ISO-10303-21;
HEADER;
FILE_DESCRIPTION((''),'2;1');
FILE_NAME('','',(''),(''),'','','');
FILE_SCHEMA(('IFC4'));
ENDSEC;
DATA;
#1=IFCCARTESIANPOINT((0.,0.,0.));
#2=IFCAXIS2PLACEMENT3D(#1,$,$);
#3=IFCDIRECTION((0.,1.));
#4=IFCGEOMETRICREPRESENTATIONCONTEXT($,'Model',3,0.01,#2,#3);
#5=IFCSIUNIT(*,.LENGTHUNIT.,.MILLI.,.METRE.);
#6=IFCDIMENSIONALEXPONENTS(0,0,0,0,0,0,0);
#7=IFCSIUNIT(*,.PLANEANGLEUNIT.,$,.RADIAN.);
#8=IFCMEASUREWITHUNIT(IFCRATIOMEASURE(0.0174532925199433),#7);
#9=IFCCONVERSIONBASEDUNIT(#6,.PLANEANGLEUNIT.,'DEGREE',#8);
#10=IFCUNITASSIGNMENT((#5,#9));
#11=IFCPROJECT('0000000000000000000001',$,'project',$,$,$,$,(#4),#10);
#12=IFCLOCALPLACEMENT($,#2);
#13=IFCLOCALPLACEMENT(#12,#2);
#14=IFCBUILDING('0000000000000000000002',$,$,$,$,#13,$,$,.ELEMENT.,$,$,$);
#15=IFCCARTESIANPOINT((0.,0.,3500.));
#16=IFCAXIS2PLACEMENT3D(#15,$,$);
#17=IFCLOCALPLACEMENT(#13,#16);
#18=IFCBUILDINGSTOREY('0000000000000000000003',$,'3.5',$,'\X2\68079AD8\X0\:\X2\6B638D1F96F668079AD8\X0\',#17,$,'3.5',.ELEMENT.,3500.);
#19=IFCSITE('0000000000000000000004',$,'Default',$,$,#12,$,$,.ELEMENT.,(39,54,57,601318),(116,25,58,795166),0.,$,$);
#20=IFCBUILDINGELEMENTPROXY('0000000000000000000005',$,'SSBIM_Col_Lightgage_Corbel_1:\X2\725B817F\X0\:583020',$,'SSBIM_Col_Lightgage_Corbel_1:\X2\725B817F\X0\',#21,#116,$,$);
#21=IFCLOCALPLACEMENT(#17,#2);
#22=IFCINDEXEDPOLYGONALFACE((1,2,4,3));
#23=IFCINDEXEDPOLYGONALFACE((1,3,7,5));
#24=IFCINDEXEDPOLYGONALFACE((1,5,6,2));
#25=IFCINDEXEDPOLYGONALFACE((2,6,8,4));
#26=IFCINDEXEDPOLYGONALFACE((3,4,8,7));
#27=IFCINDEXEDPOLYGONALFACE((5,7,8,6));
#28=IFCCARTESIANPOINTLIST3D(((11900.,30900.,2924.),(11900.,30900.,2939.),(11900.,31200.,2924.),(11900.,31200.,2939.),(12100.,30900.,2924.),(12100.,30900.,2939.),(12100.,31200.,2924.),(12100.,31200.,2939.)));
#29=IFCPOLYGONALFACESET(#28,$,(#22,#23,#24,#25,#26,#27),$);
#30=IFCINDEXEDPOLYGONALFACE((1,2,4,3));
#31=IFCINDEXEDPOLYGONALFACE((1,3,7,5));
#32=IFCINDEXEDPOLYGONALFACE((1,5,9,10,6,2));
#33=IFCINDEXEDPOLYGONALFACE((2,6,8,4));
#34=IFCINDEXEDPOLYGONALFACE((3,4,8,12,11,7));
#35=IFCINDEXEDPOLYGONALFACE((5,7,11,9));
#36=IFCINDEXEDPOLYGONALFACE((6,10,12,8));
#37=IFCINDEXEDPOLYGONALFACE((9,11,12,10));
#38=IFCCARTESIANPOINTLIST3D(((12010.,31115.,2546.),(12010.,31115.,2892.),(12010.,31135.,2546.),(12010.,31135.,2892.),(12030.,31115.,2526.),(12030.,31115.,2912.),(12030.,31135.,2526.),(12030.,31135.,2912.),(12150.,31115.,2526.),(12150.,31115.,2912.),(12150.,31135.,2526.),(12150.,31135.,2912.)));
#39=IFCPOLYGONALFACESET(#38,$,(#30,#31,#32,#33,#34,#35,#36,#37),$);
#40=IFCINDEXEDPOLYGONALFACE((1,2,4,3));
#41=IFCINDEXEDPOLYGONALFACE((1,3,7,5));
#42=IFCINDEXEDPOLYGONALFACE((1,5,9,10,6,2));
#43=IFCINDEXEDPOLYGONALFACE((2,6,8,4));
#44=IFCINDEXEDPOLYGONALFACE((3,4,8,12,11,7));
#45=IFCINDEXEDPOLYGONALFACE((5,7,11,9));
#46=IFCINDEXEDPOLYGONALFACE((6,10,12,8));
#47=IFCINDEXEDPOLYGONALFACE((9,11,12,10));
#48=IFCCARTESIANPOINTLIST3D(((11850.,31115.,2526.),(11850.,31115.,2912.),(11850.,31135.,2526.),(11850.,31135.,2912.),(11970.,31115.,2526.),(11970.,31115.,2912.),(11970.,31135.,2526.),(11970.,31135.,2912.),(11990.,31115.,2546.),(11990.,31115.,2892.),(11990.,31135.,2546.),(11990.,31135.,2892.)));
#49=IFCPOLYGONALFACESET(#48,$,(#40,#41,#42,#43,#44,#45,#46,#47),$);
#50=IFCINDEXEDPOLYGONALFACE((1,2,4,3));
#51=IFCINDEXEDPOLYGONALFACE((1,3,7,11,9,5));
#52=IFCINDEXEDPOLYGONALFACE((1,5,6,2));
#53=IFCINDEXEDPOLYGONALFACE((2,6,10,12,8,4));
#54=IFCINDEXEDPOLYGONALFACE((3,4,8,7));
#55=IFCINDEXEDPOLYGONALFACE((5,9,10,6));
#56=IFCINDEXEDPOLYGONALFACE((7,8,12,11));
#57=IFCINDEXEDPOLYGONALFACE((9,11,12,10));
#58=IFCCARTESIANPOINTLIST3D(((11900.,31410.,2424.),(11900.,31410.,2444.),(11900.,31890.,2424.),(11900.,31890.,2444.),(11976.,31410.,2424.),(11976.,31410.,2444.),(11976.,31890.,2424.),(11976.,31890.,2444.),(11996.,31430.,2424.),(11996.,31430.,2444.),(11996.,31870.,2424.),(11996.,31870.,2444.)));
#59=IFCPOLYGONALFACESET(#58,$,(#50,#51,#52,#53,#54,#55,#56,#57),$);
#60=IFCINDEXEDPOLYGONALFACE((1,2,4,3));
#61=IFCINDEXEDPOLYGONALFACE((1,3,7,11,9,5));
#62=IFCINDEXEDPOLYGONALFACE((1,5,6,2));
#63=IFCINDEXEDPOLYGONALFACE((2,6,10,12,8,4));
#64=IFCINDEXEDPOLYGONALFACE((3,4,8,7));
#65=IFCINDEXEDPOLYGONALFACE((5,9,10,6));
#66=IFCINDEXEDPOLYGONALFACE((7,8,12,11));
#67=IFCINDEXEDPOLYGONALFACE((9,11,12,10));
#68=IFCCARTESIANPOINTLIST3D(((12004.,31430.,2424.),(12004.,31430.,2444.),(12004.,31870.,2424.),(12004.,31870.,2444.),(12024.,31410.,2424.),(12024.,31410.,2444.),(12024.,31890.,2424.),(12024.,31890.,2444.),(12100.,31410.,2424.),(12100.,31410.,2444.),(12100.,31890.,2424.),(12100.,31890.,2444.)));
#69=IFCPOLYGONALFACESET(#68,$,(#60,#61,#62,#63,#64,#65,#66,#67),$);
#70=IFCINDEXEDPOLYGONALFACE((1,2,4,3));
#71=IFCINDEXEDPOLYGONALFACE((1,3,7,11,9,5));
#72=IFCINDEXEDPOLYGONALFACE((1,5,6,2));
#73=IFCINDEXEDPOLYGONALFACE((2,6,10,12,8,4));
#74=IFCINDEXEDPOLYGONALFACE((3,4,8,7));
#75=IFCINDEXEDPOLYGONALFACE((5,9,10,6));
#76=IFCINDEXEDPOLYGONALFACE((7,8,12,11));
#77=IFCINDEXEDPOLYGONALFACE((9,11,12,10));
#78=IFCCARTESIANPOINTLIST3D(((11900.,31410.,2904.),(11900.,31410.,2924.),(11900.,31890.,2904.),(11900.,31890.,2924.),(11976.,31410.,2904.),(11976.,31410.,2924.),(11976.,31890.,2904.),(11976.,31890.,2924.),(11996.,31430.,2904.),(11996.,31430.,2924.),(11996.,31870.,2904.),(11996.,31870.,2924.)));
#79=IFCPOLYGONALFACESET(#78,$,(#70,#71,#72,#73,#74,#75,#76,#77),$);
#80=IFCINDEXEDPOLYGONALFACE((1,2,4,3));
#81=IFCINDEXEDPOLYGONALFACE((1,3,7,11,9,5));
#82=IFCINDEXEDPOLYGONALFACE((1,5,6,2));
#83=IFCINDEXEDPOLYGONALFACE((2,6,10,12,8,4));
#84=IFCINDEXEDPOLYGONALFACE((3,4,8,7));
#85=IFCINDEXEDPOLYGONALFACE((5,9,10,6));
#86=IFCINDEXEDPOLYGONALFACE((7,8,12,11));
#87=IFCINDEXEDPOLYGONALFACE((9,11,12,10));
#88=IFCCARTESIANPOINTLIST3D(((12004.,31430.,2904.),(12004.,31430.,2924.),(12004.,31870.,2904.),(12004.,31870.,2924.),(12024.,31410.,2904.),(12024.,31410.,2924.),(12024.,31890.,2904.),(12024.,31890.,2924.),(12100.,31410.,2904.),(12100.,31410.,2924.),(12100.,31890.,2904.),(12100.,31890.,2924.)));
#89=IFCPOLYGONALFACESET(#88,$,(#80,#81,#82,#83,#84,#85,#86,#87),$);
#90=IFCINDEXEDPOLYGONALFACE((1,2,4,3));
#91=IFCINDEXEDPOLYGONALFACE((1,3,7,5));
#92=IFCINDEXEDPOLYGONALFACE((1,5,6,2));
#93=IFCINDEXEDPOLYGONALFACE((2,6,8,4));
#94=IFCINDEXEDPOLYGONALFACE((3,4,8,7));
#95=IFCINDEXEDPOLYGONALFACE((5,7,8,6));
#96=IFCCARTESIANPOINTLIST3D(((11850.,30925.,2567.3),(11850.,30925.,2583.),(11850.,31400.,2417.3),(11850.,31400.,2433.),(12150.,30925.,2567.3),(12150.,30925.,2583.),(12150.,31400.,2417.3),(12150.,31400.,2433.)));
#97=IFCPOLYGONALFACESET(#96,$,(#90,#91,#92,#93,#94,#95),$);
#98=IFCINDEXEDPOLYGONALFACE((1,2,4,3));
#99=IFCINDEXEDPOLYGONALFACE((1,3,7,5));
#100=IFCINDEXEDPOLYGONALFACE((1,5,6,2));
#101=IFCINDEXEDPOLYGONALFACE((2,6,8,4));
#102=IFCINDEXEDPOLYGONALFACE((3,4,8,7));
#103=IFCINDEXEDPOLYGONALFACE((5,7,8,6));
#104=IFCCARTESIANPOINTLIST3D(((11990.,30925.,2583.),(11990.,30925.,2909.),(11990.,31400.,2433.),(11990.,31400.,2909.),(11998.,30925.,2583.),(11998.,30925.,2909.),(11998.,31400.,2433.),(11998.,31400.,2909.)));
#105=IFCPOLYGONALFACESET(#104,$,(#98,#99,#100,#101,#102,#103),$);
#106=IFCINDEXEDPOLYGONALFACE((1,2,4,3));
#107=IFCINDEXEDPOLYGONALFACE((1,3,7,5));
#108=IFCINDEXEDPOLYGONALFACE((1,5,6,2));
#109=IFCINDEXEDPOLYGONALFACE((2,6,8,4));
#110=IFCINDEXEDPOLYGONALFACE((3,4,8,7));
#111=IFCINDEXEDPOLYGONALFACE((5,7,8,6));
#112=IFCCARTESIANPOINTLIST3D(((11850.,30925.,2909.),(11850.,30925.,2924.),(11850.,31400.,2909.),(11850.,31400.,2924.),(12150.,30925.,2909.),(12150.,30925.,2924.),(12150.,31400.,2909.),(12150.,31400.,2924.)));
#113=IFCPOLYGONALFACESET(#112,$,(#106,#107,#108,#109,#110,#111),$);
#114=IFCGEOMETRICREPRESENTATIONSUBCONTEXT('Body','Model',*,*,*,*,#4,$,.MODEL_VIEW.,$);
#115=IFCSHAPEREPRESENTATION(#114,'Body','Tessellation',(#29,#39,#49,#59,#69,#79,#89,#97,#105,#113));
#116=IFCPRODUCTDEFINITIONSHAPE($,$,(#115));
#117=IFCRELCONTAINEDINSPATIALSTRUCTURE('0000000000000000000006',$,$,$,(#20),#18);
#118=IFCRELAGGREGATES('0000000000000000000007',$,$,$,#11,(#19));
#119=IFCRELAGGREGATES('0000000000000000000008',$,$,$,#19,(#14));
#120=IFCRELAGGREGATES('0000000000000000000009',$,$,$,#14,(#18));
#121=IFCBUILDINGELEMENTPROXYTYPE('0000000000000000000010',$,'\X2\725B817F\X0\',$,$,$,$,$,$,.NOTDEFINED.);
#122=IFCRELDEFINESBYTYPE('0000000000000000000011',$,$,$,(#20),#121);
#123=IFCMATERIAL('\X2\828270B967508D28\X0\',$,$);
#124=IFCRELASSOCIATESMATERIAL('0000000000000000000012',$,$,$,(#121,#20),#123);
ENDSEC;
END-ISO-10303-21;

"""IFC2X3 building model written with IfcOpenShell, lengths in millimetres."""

from ifc_helpers import new_model, entity, si_unit, converted_unit, direction, frame, frame_2d, origin, origin_2d_with_axis, place, context, subcontext, project, spatial, polyline, rectangle, outline, extrude, source, transform, mapped, material, type_object, type_shapes, element, save


model = new_model("IFC2X3")

# Units and contexts
model_context = context("Model", 3, precision=0.01, world=origin(), true_north=direction((0.0, 1.0)))
body_context = subcontext(model_context, "Body", "Model", "MODEL_VIEW")
ifc_project = project(units=[si_unit("LENGTHUNIT", "METRE", prefix="MILLI"), converted_unit("PLANEANGLEUNIT", "DEGREE", entity("IfcRatioMeasure", 0.0174532925199433), si_unit("PLANEANGLEUNIT", "RADIAN"), dimensions=[0, 0, 0, 0, 0, 0, 0])], contexts=[model_context])

# Site, building, storey
site_placement = place(None, origin())
site = spatial("IfcSite", under=ifc_project, at=site_placement, Name="Default", CompositionType="ELEMENT", RefLatitude=(39, 54, 57, 601318), RefLongitude=(116, 25, 58, 795166), RefElevation=0.0)
building_placement = place(site_placement, origin())
building = spatial("IfcBuilding", under=site, at=building_placement, CompositionType="ELEMENT")
storey_placement = place(building_placement, frame((0.0, 0.0, 3500.0)))
storey = spatial("IfcBuildingStorey", under=building, at=storey_placement, Name="3.5", ObjectType="标高:正负零标高", LongName="3.5", CompositionType="ELEMENT", Elevation=3500.0)

# Building element proxy
ifc_material_1 = material(Name="节点材质")
building_element_proxy_type_1 = type_object("IfcBuildingElementProxyType", Name="牛腿", PredefinedType="NOTDEFINED", material=ifc_material_1)
shared_shape_1 = source(origin(), body_context, "Body", "SweptSolid", [
    extrude(rectangle(XDim=300.0, YDim=200.0, at=frame_2d((0.0, 0.0), x_axis=(1.0, 0.0))), frame((636.4, 0.0, 0.0)), (0.0, 0.0, 1.0), 15.0),
    extrude(outline(polyline([(-193.0, -86.7), (193.0, -86.7), (193.0, 33.3), (173.0, 53.3), (-173.0, 53.3), (-193.0, 33.3), (-193.0, -86.7)])), frame((551.4, 63.3, -205.0), z_axis=(1.0, 0.0, 0.0), x_axis=(0.0, 0.0, 1.0)), (0.0, 0.0, 1.0), 20.0),
    extrude(outline(polyline([(-86.7, -193.0), (33.3, -193.0), (53.3, -173.0), (53.3, 173.0), (33.3, 193.0), (-86.7, 193.0), (-86.7, -193.0)])), frame((551.4, -63.3, -205.0), z_axis=(1.0, 0.0, 0.0), x_axis=(0.0, 1.0, 0.0)), (0.0, 0.0, 1.0), 20.0),
    extrude(outline(polyline([(-240.0, -57.3), (240.0, -57.3), (240.0, 18.7), (220.0, 38.7), (-220.0, 38.7), (-240.0, 18.7), (-240.0, -57.3)])), frame((36.4, -42.7, -500.0)), (0.0, 0.0, 1.0), 20.0),
    extrude(outline(polyline([(-57.3, -240.0), (18.7, -240.0), (38.7, -220.0), (38.7, 220.0), (18.7, 240.0), (-57.3, 240.0), (-57.3, -240.0)])), frame((36.4, 42.7, -500.0), z_axis=(0.0, 0.0, 1.0), x_axis=(0.0, -1.0, 0.0)), (0.0, 0.0, 1.0), 20.0),
    extrude(outline(polyline([(-240.0, -57.3), (240.0, -57.3), (240.0, 18.7), (220.0, 38.7), (-220.0, 38.7), (-240.0, 18.7), (-240.0, -57.3)])), frame((36.4, -42.7, -20.0)), (0.0, 0.0, 1.0), 20.0),
    extrude(outline(polyline([(-57.3, -240.0), (18.7, -240.0), (38.7, -220.0), (38.7, 220.0), (18.7, 240.0), (-57.3, 240.0), (-57.3, -240.0)])), frame((36.4, 42.7, -20.0), z_axis=(0.0, 0.0, 1.0), x_axis=(0.0, -1.0, 0.0)), (0.0, 0.0, 1.0), 20.0),
    extrude(outline(polyline([(-246.7, -7.5), (251.4, -7.5), (246.7, 7.5), (-251.4, 7.5), (-246.7, -7.5)])), frame((523.9, -150.0, -423.9), z_axis=(0.0, 1.0, 0.0), x_axis=(0.953583, 0.0, 0.301131)), (0.0, 0.0, 1.0), 300.0),
    extrude(outline(polyline([(-237.5, -200.5), (237.5, -200.5), (237.5, 125.5), (-237.5, 275.5), (-237.5, -200.5)])), frame((523.9, -10.0, -215.5), z_axis=(0.0, 1.0, 0.0), x_axis=(1.0, 0.0, 0.0)), (0.0, 0.0, 1.0), 8.0),
    extrude(rectangle(XDim=475.0, YDim=300.0, at=origin_2d_with_axis()), frame((523.9, 0.0, -15.0)), (0.0, 0.0, 1.0), 15.0),
])
type_shapes(building_element_proxy_type_1, [shared_shape_1])
for number, where, z_axis, x_axis, name in (
    (1, (12000.0, 31686.4, 2924.0), (0.0, 0.0, 1.0), (0.0, -1.0, 0.0), "SSBIM_Col_Lightgage_Corbel_1:牛腿:583020"),
):
    element("IfcBuildingElementProxy", number, at=place(storey_placement, frame(where, z_axis=z_axis, x_axis=x_axis)), inside=storey, type_object=building_element_proxy_type_1, material=ifc_material_1, Name=name, ObjectType="SSBIM_Col_Lightgage_Corbel_1:牛腿", context=body_context, shape_type="MappedRepresentation", body=[
        mapped(shared_shape_1, transform((0.0, 0.0, 0.0), scale=1.0)),
    ])

save(model, "model.ifc")
